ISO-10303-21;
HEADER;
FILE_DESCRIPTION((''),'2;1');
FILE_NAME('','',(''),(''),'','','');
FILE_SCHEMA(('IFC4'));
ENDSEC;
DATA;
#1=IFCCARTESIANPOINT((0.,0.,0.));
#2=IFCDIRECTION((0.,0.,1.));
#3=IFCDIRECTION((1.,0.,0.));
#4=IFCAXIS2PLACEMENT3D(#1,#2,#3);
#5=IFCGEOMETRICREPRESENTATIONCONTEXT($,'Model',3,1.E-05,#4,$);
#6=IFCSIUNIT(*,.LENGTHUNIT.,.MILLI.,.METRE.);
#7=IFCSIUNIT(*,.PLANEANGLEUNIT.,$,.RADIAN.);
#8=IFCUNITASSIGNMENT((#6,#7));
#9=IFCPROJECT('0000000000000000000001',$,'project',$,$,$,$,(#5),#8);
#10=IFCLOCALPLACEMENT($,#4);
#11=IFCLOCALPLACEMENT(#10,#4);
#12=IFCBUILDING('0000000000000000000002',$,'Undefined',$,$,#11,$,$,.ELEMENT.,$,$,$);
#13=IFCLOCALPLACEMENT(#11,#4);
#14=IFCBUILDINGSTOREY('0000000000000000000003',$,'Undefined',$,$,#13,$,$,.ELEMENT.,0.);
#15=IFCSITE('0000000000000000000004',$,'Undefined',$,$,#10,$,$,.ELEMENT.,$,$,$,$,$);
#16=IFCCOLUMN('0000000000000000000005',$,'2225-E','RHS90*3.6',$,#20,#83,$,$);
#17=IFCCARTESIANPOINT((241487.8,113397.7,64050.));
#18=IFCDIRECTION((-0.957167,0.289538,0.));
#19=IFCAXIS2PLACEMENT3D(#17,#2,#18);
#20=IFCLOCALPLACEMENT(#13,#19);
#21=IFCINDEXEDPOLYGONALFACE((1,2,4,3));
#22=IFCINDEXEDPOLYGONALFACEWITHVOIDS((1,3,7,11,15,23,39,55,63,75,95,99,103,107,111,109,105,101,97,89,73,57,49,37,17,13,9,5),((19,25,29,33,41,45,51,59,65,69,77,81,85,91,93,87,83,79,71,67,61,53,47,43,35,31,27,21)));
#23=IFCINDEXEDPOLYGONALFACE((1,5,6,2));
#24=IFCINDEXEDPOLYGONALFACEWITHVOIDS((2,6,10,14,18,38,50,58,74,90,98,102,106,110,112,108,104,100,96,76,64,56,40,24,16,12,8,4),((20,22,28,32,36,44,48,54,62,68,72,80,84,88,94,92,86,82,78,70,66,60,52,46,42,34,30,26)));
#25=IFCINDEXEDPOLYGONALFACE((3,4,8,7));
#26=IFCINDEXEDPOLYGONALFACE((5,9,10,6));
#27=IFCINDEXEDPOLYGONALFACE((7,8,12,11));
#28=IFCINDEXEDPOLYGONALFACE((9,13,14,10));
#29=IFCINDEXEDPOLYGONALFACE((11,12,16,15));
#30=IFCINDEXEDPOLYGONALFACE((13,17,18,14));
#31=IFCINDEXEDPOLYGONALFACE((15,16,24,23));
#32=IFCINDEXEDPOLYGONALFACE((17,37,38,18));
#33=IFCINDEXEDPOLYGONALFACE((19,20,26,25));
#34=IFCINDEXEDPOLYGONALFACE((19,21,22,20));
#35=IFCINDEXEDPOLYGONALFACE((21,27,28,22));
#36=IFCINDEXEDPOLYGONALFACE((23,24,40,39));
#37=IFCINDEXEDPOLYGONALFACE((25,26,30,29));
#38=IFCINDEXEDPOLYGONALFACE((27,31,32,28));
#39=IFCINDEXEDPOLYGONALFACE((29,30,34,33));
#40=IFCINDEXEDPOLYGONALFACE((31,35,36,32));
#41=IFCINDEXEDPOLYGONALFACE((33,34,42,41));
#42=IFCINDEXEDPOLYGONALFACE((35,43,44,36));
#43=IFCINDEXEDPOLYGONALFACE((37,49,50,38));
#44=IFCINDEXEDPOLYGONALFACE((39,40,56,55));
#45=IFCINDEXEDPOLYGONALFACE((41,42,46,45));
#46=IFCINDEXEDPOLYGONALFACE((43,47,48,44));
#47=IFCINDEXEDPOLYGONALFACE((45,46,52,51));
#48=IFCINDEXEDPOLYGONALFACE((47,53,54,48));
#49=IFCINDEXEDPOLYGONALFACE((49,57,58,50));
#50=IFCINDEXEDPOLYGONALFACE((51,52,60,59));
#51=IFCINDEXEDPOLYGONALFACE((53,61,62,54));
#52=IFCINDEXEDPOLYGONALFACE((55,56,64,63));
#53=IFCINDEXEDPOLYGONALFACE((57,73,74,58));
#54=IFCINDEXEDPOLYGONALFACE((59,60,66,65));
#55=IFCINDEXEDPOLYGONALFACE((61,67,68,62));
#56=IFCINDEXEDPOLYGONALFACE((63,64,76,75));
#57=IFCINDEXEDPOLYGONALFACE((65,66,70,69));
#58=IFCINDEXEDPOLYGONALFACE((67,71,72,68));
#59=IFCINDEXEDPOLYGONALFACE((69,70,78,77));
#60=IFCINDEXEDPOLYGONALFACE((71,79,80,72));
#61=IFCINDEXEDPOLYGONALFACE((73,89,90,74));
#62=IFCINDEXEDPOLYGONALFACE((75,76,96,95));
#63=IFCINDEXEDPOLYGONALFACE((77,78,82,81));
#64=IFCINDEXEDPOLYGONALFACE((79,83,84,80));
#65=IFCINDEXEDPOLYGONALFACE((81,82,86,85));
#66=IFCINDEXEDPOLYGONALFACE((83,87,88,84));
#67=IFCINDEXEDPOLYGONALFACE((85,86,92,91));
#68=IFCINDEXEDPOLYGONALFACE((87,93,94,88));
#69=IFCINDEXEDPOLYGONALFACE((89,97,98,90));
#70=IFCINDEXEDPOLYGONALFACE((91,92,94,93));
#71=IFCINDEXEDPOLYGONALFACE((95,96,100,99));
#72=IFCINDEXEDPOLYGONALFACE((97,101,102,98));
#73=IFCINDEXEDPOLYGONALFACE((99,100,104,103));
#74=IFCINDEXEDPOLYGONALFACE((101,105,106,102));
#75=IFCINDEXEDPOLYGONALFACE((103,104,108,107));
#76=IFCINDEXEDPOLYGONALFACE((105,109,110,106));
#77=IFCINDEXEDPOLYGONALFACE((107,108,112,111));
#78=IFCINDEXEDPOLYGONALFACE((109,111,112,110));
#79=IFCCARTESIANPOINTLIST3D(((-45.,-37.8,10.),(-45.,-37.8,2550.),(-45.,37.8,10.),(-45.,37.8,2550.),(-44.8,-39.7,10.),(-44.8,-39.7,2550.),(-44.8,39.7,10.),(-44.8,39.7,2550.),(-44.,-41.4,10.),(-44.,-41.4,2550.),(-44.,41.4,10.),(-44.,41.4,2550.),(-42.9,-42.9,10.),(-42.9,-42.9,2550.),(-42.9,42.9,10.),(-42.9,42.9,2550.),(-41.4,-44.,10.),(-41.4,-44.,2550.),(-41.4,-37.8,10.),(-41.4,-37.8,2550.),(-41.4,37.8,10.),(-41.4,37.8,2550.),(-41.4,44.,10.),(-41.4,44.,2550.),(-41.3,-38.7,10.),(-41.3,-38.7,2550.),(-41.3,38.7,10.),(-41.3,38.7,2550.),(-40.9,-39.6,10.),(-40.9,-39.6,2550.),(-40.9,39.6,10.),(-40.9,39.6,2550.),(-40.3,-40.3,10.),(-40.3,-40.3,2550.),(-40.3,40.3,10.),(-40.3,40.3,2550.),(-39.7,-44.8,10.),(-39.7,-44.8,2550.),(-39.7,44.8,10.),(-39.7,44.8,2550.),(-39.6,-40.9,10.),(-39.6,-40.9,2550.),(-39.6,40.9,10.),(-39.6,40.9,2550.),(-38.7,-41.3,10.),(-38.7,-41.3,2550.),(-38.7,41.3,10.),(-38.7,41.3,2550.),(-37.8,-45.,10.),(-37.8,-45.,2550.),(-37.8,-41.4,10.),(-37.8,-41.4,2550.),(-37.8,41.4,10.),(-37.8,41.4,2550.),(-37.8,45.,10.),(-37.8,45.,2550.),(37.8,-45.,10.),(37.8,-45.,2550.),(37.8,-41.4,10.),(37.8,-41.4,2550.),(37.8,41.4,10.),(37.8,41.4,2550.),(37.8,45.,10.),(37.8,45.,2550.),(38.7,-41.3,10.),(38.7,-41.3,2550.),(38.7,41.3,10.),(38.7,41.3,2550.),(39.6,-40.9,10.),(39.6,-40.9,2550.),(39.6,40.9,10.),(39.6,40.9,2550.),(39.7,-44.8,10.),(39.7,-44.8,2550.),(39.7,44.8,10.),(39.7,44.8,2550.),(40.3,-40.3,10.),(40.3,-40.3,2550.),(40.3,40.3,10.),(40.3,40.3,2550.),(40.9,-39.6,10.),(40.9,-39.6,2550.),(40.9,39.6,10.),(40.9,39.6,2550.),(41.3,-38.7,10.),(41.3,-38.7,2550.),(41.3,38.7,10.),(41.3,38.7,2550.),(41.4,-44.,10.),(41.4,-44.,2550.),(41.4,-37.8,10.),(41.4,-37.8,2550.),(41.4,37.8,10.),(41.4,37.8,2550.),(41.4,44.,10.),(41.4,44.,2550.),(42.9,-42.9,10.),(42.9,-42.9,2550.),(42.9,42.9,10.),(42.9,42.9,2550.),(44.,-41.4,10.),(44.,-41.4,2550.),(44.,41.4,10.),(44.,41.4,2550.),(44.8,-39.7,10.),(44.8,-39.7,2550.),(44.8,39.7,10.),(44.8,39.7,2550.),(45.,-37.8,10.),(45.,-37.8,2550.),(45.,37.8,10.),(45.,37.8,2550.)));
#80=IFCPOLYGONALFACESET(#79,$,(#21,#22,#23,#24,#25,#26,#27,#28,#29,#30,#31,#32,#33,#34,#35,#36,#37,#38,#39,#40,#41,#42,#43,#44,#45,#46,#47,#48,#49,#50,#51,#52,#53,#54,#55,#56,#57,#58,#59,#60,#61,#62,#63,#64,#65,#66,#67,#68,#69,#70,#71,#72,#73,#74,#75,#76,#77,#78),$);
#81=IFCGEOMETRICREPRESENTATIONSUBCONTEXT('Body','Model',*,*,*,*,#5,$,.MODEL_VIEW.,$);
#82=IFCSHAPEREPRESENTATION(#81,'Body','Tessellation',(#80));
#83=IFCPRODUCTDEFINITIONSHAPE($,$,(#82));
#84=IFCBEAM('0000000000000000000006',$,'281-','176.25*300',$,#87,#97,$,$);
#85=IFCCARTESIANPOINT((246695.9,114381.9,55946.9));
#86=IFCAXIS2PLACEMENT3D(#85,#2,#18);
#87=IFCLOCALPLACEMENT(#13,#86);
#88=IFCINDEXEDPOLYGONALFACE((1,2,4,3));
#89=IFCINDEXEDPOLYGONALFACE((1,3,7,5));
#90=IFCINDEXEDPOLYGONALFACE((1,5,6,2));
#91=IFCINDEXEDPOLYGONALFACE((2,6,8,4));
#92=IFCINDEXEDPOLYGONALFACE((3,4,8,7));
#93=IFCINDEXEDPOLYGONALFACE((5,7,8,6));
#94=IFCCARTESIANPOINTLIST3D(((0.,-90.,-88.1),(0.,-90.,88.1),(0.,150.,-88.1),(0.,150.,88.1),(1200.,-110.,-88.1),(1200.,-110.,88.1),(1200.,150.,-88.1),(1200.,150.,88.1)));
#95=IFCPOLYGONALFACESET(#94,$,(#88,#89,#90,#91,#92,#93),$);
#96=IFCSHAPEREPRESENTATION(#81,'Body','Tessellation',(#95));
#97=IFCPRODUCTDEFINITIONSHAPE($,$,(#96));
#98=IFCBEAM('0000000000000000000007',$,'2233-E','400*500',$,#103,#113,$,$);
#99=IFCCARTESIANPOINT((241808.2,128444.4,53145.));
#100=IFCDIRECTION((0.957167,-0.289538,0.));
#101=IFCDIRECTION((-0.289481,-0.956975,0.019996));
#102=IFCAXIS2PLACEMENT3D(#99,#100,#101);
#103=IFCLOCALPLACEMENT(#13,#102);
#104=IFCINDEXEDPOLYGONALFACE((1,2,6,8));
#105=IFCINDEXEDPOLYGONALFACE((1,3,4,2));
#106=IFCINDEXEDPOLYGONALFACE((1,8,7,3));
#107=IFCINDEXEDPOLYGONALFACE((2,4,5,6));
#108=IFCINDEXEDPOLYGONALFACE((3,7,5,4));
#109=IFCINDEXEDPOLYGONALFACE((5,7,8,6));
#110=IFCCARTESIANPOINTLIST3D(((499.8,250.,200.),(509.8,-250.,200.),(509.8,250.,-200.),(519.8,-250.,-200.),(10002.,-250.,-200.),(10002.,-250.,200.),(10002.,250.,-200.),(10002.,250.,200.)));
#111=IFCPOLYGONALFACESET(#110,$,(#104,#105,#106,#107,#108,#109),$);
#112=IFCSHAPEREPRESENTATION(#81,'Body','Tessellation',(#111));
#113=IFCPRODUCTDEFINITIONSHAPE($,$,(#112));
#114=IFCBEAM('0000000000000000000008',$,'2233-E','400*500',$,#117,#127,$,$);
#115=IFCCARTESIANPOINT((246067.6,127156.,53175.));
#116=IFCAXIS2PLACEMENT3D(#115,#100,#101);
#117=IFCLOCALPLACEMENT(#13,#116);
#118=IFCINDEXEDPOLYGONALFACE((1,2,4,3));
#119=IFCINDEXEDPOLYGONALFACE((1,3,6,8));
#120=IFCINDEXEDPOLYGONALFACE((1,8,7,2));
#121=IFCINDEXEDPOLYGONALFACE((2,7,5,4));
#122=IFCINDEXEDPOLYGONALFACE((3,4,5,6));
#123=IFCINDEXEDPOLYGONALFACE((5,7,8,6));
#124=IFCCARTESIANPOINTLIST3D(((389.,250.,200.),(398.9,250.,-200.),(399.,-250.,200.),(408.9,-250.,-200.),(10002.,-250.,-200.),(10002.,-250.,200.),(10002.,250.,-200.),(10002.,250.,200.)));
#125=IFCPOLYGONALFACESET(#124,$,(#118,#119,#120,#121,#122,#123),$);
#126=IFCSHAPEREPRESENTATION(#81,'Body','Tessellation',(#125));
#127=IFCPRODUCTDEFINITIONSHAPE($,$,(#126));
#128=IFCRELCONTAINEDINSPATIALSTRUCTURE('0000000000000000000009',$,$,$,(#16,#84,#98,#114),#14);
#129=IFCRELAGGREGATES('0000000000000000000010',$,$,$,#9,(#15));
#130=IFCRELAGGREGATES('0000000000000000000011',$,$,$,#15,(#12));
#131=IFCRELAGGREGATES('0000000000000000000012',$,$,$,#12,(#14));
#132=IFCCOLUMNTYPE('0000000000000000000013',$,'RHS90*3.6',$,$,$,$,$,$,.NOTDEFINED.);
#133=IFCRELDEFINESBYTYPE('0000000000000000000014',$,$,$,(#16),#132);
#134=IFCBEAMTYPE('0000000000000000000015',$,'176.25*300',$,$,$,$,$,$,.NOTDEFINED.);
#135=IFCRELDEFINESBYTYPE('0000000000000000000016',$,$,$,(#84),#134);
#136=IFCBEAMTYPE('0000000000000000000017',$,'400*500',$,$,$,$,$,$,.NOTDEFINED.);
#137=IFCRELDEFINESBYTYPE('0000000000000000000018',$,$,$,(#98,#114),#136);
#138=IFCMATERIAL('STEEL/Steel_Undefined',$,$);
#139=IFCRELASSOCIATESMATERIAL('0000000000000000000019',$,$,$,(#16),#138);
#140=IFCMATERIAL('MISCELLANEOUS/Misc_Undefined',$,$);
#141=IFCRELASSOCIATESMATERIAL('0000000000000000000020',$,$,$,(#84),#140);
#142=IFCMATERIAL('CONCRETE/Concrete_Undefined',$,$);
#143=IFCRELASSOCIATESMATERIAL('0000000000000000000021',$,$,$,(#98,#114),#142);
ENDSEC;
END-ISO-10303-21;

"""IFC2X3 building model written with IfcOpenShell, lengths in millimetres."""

from ifc_helpers import new_model, si_unit, frame, origin_with_axes, origin_2d_with_axis, place, context, subcontext, project, spatial, rectangle, hollow_rectangle, extrude, clip, halfspace, material, type_object, element, save


model = new_model("IFC2X3")

# Units and contexts
model_context = context("Model", 3, precision=1e-05, world=origin_with_axes())
body_context = subcontext(model_context, "Body", "Model", "MODEL_VIEW")
ifc_project = project(units=[si_unit("LENGTHUNIT", "METRE", prefix="MILLI"), si_unit("PLANEANGLEUNIT", "RADIAN")], contexts=[model_context])

# Site, building, storey
site_placement = place(None, origin_with_axes())
site = spatial("IfcSite", under=ifc_project, at=site_placement, Name="Undefined", CompositionType="ELEMENT")
building_placement = place(site_placement, origin_with_axes())
building = spatial("IfcBuilding", under=site, at=building_placement, Name="Undefined", CompositionType="ELEMENT")
storey_placement = place(building_placement, origin_with_axes())
storey = spatial("IfcBuildingStorey", under=building, at=storey_placement, Name="Undefined", CompositionType="ELEMENT", Elevation=0.0)

# Column
ifc_material_1 = material(Name="STEEL/Steel_Undefined")
column_type = type_object("IfcColumnType", Name="RHS90*3.6", PredefinedType="NOTDEFINED")
column_placement = place(storey_placement, frame((241487.8, 113397.7, 64050.0), z_axis=(0.0, 0.0, 1.0), x_axis=(-0.957167, 0.289538, 0.0)))
element("IfcColumn", 1, at=column_placement, inside=storey, type_object=column_type, material=ifc_material_1, Name="2225-E", Description="RHS90*3.6", context=body_context, shape_type="Clipping", body=[
    clip(extrude(hollow_rectangle(XDim=90.0, YDim=90.0, WallThickness=3.6, InnerFilletRadius=3.6, OuterFilletRadius=7.2, at=origin_2d_with_axis()), frame((0.0, 0.0, 2550.0), z_axis=(0.0, 0.0, -1.0), x_axis=(0.0, 1.0, 0.0)), (0.0, 0.0, 1.0), 2550.0), halfspace(frame((-45.0, 0.0, 10.0), z_axis=(0.0, 0.0, 1.0), x_axis=(0.0, 1.0, 0.0)), True)),
])

# Beams
ifc_material_2 = material(Name="MISCELLANEOUS/Misc_Undefined")
beam_type_1 = type_object("IfcBeamType", Name="176.25*300", PredefinedType="NOTDEFINED")
beam_1_placement = place(storey_placement, frame((246695.9, 114381.9, 55946.9), z_axis=(0.0, 0.0, 1.0), x_axis=(-0.957167, 0.289538, 0.0)))
element("IfcBeam", 2, at=beam_1_placement, inside=storey, type_object=beam_type_1, material=ifc_material_2, Name="281-", Description="176.25*300", context=body_context, shape_type="Clipping", body=[
    clip(extrude(rectangle(XDim=300.0, YDim=176.2, at=origin_2d_with_axis()), frame((1200.0, 0.0, 0.0), z_axis=(-1.0, 0.0, 0.0), x_axis=(0.0, -1.0, 0.0)), (0.0, 0.0, 1.0), 1200.0), halfspace(frame((0.0, -90.0, -88.1), z_axis=(-0.016664, -0.999861, 0.0), x_axis=(0.0, 0.0, 1.0)), False)),
])
ifc_material_3 = material(Name="CONCRETE/Concrete_Undefined")
beam_type_2 = type_object("IfcBeamType", Name="400*500", PredefinedType="NOTDEFINED")
beam_2_placement = place(storey_placement, frame((241808.2, 128444.4, 53145.0), z_axis=(0.957167, -0.289538, 0.0), x_axis=(-0.289481, -0.956975, 0.019996)))
element("IfcBeam", 3, at=beam_2_placement, inside=storey, type_object=beam_type_2, material=ifc_material_3, Name="2233-E", Description="400*500", context=body_context, shape_type="Clipping", body=[
    clip(extrude(rectangle(XDim=500.0, YDim=400.0, at=origin_2d_with_axis()), frame((10002.0, 0.0, 0.0), z_axis=(-1.0, 0.0, 0.0), x_axis=(0.0, -1.0, 0.0)), (0.0, 0.0, 1.0), 10002.0), halfspace(frame((509.8, -250.0, 200.0), z_axis=(-0.99949, -0.01999, -0.024903), x_axis=(0.024908, 0.0, -0.99969)), False)),
])
beam_3_placement = place(storey_placement, frame((246067.6, 127156.0, 53175.0), z_axis=(0.957167, -0.289538, 0.0), x_axis=(-0.289481, -0.956975, 0.019996)))
element("IfcBeam", 4, at=beam_3_placement, inside=storey, type_object=beam_type_2, material=ifc_material_3, Name="2233-E", Description="400*500", context=body_context, shape_type="Clipping", body=[
    clip(extrude(rectangle(XDim=500.0, YDim=400.0, at=origin_2d_with_axis()), frame((10002.0, 0.0, 0.0), z_axis=(-1.0, 0.0, 0.0), x_axis=(0.0, -1.0, 0.0)), (0.0, 0.0, 1.0), 10002.0), halfspace(frame((399.0, -250.0, 200.0), z_axis=(-0.99949, -0.01999, -0.024903), x_axis=(0.024908, 0.0, -0.99969)), False)),
])

save(model, "model.ifc")
